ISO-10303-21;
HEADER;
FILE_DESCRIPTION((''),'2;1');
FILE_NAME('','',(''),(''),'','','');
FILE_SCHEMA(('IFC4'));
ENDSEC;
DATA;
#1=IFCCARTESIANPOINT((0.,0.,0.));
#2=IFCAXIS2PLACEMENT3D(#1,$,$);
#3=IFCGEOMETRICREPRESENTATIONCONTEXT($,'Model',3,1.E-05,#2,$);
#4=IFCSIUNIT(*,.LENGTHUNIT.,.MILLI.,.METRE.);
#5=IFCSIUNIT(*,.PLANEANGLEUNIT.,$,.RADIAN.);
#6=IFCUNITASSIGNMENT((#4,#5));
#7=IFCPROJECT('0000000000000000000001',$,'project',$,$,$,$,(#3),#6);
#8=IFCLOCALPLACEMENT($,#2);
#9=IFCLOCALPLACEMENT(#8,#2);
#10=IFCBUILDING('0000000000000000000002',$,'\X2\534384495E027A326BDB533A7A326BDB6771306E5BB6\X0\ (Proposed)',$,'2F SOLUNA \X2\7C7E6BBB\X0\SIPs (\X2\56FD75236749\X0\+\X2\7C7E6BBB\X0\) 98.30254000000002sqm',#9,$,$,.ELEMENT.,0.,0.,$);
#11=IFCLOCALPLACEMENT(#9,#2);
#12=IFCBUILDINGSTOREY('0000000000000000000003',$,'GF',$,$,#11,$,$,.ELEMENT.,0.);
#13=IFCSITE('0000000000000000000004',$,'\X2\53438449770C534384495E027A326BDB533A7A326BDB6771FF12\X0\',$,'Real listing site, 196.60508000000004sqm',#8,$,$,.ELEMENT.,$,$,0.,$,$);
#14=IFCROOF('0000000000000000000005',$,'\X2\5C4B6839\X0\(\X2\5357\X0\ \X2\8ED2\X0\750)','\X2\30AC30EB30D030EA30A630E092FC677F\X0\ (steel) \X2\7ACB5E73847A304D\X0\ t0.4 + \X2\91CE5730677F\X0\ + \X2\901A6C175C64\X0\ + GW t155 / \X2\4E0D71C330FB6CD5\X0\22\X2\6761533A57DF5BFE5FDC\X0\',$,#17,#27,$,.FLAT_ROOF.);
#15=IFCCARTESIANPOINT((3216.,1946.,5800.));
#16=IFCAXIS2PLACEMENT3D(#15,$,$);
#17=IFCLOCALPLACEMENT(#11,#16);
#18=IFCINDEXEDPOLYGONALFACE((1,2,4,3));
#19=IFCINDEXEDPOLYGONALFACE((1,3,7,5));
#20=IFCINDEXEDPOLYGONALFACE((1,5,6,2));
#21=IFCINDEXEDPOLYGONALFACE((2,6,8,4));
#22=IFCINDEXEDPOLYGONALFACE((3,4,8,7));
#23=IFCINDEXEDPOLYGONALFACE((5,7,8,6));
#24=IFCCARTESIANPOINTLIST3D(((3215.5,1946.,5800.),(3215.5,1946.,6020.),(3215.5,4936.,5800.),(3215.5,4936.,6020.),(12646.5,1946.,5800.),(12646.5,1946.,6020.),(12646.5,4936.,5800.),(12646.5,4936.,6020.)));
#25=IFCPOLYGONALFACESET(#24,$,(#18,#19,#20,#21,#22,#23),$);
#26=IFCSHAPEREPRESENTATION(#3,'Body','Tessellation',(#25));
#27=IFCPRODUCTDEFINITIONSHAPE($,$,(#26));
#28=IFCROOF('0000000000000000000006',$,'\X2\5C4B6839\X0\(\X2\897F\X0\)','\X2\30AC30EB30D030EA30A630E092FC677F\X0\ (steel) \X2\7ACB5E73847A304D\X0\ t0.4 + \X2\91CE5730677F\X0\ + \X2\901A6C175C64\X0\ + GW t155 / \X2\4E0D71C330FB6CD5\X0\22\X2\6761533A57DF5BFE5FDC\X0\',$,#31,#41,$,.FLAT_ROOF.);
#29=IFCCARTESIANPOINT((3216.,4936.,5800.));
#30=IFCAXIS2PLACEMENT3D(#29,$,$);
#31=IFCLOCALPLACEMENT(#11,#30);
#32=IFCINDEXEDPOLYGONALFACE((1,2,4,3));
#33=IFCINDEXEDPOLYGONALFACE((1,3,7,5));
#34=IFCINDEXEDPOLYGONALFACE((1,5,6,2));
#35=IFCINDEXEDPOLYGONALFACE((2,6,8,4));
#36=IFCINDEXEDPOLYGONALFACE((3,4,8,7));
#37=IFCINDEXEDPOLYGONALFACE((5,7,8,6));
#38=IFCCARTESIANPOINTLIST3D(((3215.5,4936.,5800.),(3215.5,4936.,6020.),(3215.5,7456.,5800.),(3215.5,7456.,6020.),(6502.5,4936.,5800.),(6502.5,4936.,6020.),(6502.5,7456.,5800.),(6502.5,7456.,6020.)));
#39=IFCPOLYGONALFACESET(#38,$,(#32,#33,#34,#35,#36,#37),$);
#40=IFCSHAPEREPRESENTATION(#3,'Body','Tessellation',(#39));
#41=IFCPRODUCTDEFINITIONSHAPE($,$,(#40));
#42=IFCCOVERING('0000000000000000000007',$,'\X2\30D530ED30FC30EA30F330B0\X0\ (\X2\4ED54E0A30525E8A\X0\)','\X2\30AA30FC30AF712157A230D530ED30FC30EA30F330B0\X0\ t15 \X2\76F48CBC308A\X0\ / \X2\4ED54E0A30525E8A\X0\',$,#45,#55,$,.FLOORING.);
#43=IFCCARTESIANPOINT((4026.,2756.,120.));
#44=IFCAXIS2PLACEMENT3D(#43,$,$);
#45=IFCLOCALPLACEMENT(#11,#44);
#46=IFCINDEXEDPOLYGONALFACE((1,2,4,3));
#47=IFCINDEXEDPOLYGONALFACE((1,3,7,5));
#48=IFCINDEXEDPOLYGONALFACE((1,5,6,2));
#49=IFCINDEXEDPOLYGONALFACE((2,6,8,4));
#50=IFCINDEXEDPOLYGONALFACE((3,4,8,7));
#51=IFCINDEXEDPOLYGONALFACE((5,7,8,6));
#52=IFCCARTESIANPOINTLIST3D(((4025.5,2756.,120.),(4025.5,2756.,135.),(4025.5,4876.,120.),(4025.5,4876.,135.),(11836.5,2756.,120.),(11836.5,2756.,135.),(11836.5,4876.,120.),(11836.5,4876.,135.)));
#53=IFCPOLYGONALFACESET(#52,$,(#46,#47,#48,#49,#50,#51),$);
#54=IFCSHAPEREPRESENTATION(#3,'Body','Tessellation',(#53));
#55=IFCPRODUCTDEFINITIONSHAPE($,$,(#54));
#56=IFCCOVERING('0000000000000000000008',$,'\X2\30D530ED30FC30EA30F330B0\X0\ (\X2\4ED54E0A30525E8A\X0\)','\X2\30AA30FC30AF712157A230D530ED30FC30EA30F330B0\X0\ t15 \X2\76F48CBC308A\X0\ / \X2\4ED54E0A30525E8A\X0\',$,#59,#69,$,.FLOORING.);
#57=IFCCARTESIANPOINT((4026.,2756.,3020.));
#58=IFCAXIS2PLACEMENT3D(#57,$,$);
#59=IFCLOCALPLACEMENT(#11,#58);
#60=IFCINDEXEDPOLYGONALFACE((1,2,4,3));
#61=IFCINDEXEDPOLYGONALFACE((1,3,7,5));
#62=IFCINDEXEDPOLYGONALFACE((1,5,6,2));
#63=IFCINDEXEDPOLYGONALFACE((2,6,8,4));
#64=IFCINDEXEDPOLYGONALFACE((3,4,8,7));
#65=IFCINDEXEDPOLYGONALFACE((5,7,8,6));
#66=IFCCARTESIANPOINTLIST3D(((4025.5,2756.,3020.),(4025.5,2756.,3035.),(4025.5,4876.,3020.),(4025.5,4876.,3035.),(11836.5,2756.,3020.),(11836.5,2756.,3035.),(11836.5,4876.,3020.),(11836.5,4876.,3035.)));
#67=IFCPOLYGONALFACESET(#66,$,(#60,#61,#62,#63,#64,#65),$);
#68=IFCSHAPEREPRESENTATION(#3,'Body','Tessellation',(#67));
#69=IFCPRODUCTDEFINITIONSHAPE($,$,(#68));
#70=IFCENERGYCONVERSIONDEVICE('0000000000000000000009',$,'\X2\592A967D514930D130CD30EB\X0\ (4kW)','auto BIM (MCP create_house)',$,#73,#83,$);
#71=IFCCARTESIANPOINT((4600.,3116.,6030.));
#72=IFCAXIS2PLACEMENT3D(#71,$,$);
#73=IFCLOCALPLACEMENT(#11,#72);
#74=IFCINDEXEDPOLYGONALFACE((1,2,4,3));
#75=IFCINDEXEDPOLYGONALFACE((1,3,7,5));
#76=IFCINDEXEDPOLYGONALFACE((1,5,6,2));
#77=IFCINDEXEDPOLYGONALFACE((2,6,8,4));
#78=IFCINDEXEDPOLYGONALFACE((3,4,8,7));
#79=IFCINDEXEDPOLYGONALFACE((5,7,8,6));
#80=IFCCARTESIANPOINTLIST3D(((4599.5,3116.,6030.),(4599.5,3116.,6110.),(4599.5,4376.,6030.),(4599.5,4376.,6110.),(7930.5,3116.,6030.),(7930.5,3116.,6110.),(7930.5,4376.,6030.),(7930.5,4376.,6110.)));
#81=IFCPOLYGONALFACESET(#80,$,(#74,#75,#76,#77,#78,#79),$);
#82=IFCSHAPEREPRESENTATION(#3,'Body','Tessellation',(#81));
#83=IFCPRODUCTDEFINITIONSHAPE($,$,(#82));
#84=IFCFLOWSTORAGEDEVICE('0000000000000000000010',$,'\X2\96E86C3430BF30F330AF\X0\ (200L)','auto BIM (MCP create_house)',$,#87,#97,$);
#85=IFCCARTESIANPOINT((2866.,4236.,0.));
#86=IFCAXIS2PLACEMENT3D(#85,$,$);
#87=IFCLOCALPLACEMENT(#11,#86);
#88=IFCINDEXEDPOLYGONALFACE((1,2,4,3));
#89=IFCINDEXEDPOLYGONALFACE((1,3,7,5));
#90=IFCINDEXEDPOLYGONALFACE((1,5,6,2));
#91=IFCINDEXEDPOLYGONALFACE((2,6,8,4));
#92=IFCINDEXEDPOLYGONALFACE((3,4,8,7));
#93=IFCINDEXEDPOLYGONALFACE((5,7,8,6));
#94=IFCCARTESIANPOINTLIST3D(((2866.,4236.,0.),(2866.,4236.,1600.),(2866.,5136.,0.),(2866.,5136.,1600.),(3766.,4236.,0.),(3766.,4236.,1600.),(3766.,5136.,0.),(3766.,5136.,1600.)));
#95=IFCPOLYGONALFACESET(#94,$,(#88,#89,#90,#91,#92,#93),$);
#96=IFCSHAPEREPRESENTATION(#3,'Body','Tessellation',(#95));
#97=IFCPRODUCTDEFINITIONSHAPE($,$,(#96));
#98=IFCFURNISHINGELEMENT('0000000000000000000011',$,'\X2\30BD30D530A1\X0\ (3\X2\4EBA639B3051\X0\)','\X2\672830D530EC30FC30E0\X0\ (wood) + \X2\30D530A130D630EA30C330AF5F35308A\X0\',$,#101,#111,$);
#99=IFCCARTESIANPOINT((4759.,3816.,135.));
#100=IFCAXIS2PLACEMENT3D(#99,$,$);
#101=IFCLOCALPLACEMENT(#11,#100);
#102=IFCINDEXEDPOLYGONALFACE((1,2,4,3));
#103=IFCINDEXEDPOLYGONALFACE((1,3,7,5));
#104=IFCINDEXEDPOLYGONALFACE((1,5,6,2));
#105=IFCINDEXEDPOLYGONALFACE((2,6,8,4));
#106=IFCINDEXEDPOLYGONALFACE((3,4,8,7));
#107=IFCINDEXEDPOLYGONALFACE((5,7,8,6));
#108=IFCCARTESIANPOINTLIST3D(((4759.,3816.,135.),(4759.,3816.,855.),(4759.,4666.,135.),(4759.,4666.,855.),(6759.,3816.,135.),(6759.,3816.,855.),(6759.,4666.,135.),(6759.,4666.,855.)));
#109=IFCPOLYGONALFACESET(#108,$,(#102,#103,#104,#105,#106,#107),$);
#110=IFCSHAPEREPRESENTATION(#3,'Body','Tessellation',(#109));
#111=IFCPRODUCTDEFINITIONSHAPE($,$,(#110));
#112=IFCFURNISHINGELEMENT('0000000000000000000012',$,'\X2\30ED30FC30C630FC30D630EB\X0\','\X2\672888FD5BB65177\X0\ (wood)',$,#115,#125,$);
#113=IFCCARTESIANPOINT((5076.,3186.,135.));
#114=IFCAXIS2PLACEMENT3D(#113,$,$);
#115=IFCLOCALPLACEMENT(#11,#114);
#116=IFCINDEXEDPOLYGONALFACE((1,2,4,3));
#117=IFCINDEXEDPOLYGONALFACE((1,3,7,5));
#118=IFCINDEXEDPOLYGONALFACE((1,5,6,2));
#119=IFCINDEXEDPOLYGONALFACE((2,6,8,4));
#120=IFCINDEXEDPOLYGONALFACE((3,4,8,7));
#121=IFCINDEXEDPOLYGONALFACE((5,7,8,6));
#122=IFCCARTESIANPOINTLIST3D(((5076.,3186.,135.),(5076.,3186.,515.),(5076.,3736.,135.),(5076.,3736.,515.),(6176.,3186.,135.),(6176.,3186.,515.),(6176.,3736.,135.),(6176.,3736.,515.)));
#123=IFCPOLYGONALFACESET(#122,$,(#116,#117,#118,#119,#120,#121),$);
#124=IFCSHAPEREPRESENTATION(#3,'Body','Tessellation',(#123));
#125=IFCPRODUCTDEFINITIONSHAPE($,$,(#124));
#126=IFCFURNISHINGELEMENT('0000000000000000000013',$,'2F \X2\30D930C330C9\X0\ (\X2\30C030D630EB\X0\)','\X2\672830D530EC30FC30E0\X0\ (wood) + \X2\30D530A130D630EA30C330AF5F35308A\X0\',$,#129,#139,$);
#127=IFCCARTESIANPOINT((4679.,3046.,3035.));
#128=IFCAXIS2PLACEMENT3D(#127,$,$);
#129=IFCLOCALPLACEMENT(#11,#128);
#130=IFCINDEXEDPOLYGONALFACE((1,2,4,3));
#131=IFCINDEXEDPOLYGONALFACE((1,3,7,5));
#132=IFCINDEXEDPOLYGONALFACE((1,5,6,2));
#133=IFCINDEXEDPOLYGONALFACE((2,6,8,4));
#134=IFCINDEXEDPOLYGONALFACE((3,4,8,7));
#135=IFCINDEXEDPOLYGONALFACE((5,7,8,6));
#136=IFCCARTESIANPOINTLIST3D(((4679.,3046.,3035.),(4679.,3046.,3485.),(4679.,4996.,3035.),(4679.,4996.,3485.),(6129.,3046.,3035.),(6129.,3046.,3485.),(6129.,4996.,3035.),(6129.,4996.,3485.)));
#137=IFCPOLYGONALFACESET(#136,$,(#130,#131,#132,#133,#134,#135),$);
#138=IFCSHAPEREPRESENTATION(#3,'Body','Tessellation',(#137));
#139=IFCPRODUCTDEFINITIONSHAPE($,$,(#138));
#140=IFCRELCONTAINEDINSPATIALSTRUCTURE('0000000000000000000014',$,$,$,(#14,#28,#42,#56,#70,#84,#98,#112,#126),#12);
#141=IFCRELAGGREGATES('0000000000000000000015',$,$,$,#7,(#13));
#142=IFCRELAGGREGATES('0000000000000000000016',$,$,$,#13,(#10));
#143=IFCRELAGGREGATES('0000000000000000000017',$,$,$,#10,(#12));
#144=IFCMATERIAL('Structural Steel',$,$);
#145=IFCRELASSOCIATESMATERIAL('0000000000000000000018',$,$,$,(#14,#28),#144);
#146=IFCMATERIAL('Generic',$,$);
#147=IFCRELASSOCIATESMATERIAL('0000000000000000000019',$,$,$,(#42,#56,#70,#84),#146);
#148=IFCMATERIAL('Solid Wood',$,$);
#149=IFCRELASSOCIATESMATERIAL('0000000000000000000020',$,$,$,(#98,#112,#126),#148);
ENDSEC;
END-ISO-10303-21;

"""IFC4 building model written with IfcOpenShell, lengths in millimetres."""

from ifc_helpers import new_model, si_unit, frame, frame_2d, origin, place, context, project, spatial, rectangle, extrude, material, element, save


model = new_model("IFC4")

# Units and contexts
model_context = context("Model", 3, precision=1e-05, world=origin())
ifc_project = project(units=[si_unit("LENGTHUNIT", "METRE", prefix="MILLI"), si_unit("PLANEANGLEUNIT", "RADIAN")], contexts=[model_context])

# Site, building, storey
site_placement = place(None, origin())
site = spatial("IfcSite", under=ifc_project, at=site_placement, Name="千葉県千葉市稲毛区稲毛東２", ObjectType="Real listing site, 196.60508000000004sqm", CompositionType="ELEMENT", RefElevation=0.0)
building_placement = place(site_placement, origin())
building = spatial("IfcBuilding", under=site, at=building_placement, Name="千葉市稲毛区稲毛東の家 (Proposed)", ObjectType="2F SOLUNA 籾殻SIPs (国産杉+籾殻) 98.30254000000002sqm", CompositionType="ELEMENT", ElevationOfRefHeight=0.0, ElevationOfTerrain=0.0)
storey_placement = place(building_placement, origin())
storey = spatial("IfcBuildingStorey", under=building, at=storey_placement, Name="GF", CompositionType="ELEMENT", Elevation=0.0)

# Shared definitions
ifc_material_1 = material(Name="Solid Wood")

# Roofs
ifc_material_2 = material(Name="Structural Steel")
roof_1_placement = place(storey_placement, frame((3216.0, 1946.0, 5800.0)))
element("IfcRoof", 1, at=roof_1_placement, inside=storey, material=ifc_material_2, Name="屋根(南 軒750)", Description="ガルバリウム鋼板 (steel) 立平葺き t0.4 + 野地板 + 通気層 + GW t155 / 不燃・法22条区域対応", PredefinedType="FLAT_ROOF", context=model_context, shape_type="SweptSolid", body=[
    extrude(rectangle(XDim=9431.0, YDim=2990.0, at=frame_2d((4715.0, 1495.0))), frame((3216.0, 1946.0, 5800.0)), (0.0, 0.0, 1.0), 220.0),
])
roof_2_placement = place(storey_placement, frame((3216.0, 4936.0, 5800.0)))
element("IfcRoof", 2, at=roof_2_placement, inside=storey, material=ifc_material_2, Name="屋根(西)", Description="ガルバリウム鋼板 (steel) 立平葺き t0.4 + 野地板 + 通気層 + GW t155 / 不燃・法22条区域対応", PredefinedType="FLAT_ROOF", context=model_context, shape_type="SweptSolid", body=[
    extrude(rectangle(XDim=3287.0, YDim=2520.0, at=frame_2d((1643.0, 1260.0))), frame((3216.0, 4936.0, 5800.0)), (0.0, 0.0, 1.0), 220.0),
])

# Coverings
ifc_material_3 = material(Name="Generic")
covering_1_placement = place(storey_placement, frame((4026.0, 2756.0, 120.0)))
element("IfcCovering", 3, at=covering_1_placement, inside=storey, material=ifc_material_3, Name="フローリング (仕上げ床)", Description="オーク無垢フローリング t15 直貼り / 仕上げ床", PredefinedType="FLOORING", context=model_context, shape_type="SweptSolid", body=[
    extrude(rectangle(XDim=7811.0, YDim=2120.0, at=frame_2d((3905.0, 1060.0))), frame((4026.0, 2756.0, 120.0)), (0.0, 0.0, 1.0), 15.0),
])
covering_2_placement = place(storey_placement, frame((4026.0, 2756.0, 3020.0)))
element("IfcCovering", 4, at=covering_2_placement, inside=storey, material=ifc_material_3, Name="フローリング (仕上げ床)", Description="オーク無垢フローリング t15 直貼り / 仕上げ床", PredefinedType="FLOORING", context=model_context, shape_type="SweptSolid", body=[
    extrude(rectangle(XDim=7811.0, YDim=2120.0, at=frame_2d((3905.0, 1060.0))), frame((4026.0, 2756.0, 3020.0)), (0.0, 0.0, 1.0), 15.0),
])

# Energy conversion device
energy_conversion_device_placement = place(storey_placement, frame((4600.0, 3116.0, 6030.0)))
element("IfcEnergyConversionDevice", 5, at=energy_conversion_device_placement, inside=storey, material=ifc_material_3, Name="太陽光パネル (4kW)", Description="auto BIM (MCP create_house)", context=model_context, shape_type="SweptSolid", body=[
    extrude(rectangle(XDim=3331.0, YDim=1260.0, at=frame_2d((1665.0, 630.0))), frame((4600.0, 3116.0, 6030.0)), (0.0, 0.0, 1.0), 80.0),
])

# Flow storage device
flow_storage_device_placement = place(storey_placement, frame((2866.0, 4236.0, 0.0)))
element("IfcFlowStorageDevice", 6, at=flow_storage_device_placement, inside=storey, material=ifc_material_3, Name="雨水タンク (200L)", Description="auto BIM (MCP create_house)", context=model_context, shape_type="SweptSolid", body=[
    extrude(rectangle(XDim=900.0, YDim=900.0, at=frame_2d((450.0, 450.0))), frame((2866.0, 4236.0, 0.0)), (0.0, 0.0, 1.0), 1600.0),
])

# Furnishing elements
furnishing_1_placement = place(storey_placement, frame((4759.0, 3816.0, 135.0)))
element("IfcFurnishingElement", 7, at=furnishing_1_placement, inside=storey, material=ifc_material_1, Name="ソファ (3人掛け)", Description="木フレーム (wood) + ファブリック張り", context=model_context, shape_type="SweptSolid", body=[
    extrude(rectangle(XDim=2000.0, YDim=850.0, at=frame_2d((1000.0, 425.0))), frame((4759.0, 3816.0, 135.0)), (0.0, 0.0, 1.0), 720.0),
])
furnishing_2_placement = place(storey_placement, frame((5076.0, 3186.0, 135.0)))
element("IfcFurnishingElement", 8, at=furnishing_2_placement, inside=storey, material=ifc_material_1, Name="ローテーブル", Description="木製家具 (wood)", context=model_context, shape_type="SweptSolid", body=[
    extrude(rectangle(XDim=1100.0, YDim=550.0, at=frame_2d((550.0, 275.0))), frame((5076.0, 3186.0, 135.0)), (0.0, 0.0, 1.0), 380.0),
])
furnishing_3_placement = place(storey_placement, frame((4679.0, 3046.0, 3035.0)))
element("IfcFurnishingElement", 9, at=furnishing_3_placement, inside=storey, material=ifc_material_1, Name="2F ベッド (ダブル)", Description="木フレーム (wood) + ファブリック張り", context=model_context, shape_type="SweptSolid", body=[
    extrude(rectangle(XDim=1450.0, YDim=1950.0, at=frame_2d((725.0, 975.0))), frame((4679.0, 3046.0, 3035.0)), (0.0, 0.0, 1.0), 450.0),
])

save(model, "model.ifc")
